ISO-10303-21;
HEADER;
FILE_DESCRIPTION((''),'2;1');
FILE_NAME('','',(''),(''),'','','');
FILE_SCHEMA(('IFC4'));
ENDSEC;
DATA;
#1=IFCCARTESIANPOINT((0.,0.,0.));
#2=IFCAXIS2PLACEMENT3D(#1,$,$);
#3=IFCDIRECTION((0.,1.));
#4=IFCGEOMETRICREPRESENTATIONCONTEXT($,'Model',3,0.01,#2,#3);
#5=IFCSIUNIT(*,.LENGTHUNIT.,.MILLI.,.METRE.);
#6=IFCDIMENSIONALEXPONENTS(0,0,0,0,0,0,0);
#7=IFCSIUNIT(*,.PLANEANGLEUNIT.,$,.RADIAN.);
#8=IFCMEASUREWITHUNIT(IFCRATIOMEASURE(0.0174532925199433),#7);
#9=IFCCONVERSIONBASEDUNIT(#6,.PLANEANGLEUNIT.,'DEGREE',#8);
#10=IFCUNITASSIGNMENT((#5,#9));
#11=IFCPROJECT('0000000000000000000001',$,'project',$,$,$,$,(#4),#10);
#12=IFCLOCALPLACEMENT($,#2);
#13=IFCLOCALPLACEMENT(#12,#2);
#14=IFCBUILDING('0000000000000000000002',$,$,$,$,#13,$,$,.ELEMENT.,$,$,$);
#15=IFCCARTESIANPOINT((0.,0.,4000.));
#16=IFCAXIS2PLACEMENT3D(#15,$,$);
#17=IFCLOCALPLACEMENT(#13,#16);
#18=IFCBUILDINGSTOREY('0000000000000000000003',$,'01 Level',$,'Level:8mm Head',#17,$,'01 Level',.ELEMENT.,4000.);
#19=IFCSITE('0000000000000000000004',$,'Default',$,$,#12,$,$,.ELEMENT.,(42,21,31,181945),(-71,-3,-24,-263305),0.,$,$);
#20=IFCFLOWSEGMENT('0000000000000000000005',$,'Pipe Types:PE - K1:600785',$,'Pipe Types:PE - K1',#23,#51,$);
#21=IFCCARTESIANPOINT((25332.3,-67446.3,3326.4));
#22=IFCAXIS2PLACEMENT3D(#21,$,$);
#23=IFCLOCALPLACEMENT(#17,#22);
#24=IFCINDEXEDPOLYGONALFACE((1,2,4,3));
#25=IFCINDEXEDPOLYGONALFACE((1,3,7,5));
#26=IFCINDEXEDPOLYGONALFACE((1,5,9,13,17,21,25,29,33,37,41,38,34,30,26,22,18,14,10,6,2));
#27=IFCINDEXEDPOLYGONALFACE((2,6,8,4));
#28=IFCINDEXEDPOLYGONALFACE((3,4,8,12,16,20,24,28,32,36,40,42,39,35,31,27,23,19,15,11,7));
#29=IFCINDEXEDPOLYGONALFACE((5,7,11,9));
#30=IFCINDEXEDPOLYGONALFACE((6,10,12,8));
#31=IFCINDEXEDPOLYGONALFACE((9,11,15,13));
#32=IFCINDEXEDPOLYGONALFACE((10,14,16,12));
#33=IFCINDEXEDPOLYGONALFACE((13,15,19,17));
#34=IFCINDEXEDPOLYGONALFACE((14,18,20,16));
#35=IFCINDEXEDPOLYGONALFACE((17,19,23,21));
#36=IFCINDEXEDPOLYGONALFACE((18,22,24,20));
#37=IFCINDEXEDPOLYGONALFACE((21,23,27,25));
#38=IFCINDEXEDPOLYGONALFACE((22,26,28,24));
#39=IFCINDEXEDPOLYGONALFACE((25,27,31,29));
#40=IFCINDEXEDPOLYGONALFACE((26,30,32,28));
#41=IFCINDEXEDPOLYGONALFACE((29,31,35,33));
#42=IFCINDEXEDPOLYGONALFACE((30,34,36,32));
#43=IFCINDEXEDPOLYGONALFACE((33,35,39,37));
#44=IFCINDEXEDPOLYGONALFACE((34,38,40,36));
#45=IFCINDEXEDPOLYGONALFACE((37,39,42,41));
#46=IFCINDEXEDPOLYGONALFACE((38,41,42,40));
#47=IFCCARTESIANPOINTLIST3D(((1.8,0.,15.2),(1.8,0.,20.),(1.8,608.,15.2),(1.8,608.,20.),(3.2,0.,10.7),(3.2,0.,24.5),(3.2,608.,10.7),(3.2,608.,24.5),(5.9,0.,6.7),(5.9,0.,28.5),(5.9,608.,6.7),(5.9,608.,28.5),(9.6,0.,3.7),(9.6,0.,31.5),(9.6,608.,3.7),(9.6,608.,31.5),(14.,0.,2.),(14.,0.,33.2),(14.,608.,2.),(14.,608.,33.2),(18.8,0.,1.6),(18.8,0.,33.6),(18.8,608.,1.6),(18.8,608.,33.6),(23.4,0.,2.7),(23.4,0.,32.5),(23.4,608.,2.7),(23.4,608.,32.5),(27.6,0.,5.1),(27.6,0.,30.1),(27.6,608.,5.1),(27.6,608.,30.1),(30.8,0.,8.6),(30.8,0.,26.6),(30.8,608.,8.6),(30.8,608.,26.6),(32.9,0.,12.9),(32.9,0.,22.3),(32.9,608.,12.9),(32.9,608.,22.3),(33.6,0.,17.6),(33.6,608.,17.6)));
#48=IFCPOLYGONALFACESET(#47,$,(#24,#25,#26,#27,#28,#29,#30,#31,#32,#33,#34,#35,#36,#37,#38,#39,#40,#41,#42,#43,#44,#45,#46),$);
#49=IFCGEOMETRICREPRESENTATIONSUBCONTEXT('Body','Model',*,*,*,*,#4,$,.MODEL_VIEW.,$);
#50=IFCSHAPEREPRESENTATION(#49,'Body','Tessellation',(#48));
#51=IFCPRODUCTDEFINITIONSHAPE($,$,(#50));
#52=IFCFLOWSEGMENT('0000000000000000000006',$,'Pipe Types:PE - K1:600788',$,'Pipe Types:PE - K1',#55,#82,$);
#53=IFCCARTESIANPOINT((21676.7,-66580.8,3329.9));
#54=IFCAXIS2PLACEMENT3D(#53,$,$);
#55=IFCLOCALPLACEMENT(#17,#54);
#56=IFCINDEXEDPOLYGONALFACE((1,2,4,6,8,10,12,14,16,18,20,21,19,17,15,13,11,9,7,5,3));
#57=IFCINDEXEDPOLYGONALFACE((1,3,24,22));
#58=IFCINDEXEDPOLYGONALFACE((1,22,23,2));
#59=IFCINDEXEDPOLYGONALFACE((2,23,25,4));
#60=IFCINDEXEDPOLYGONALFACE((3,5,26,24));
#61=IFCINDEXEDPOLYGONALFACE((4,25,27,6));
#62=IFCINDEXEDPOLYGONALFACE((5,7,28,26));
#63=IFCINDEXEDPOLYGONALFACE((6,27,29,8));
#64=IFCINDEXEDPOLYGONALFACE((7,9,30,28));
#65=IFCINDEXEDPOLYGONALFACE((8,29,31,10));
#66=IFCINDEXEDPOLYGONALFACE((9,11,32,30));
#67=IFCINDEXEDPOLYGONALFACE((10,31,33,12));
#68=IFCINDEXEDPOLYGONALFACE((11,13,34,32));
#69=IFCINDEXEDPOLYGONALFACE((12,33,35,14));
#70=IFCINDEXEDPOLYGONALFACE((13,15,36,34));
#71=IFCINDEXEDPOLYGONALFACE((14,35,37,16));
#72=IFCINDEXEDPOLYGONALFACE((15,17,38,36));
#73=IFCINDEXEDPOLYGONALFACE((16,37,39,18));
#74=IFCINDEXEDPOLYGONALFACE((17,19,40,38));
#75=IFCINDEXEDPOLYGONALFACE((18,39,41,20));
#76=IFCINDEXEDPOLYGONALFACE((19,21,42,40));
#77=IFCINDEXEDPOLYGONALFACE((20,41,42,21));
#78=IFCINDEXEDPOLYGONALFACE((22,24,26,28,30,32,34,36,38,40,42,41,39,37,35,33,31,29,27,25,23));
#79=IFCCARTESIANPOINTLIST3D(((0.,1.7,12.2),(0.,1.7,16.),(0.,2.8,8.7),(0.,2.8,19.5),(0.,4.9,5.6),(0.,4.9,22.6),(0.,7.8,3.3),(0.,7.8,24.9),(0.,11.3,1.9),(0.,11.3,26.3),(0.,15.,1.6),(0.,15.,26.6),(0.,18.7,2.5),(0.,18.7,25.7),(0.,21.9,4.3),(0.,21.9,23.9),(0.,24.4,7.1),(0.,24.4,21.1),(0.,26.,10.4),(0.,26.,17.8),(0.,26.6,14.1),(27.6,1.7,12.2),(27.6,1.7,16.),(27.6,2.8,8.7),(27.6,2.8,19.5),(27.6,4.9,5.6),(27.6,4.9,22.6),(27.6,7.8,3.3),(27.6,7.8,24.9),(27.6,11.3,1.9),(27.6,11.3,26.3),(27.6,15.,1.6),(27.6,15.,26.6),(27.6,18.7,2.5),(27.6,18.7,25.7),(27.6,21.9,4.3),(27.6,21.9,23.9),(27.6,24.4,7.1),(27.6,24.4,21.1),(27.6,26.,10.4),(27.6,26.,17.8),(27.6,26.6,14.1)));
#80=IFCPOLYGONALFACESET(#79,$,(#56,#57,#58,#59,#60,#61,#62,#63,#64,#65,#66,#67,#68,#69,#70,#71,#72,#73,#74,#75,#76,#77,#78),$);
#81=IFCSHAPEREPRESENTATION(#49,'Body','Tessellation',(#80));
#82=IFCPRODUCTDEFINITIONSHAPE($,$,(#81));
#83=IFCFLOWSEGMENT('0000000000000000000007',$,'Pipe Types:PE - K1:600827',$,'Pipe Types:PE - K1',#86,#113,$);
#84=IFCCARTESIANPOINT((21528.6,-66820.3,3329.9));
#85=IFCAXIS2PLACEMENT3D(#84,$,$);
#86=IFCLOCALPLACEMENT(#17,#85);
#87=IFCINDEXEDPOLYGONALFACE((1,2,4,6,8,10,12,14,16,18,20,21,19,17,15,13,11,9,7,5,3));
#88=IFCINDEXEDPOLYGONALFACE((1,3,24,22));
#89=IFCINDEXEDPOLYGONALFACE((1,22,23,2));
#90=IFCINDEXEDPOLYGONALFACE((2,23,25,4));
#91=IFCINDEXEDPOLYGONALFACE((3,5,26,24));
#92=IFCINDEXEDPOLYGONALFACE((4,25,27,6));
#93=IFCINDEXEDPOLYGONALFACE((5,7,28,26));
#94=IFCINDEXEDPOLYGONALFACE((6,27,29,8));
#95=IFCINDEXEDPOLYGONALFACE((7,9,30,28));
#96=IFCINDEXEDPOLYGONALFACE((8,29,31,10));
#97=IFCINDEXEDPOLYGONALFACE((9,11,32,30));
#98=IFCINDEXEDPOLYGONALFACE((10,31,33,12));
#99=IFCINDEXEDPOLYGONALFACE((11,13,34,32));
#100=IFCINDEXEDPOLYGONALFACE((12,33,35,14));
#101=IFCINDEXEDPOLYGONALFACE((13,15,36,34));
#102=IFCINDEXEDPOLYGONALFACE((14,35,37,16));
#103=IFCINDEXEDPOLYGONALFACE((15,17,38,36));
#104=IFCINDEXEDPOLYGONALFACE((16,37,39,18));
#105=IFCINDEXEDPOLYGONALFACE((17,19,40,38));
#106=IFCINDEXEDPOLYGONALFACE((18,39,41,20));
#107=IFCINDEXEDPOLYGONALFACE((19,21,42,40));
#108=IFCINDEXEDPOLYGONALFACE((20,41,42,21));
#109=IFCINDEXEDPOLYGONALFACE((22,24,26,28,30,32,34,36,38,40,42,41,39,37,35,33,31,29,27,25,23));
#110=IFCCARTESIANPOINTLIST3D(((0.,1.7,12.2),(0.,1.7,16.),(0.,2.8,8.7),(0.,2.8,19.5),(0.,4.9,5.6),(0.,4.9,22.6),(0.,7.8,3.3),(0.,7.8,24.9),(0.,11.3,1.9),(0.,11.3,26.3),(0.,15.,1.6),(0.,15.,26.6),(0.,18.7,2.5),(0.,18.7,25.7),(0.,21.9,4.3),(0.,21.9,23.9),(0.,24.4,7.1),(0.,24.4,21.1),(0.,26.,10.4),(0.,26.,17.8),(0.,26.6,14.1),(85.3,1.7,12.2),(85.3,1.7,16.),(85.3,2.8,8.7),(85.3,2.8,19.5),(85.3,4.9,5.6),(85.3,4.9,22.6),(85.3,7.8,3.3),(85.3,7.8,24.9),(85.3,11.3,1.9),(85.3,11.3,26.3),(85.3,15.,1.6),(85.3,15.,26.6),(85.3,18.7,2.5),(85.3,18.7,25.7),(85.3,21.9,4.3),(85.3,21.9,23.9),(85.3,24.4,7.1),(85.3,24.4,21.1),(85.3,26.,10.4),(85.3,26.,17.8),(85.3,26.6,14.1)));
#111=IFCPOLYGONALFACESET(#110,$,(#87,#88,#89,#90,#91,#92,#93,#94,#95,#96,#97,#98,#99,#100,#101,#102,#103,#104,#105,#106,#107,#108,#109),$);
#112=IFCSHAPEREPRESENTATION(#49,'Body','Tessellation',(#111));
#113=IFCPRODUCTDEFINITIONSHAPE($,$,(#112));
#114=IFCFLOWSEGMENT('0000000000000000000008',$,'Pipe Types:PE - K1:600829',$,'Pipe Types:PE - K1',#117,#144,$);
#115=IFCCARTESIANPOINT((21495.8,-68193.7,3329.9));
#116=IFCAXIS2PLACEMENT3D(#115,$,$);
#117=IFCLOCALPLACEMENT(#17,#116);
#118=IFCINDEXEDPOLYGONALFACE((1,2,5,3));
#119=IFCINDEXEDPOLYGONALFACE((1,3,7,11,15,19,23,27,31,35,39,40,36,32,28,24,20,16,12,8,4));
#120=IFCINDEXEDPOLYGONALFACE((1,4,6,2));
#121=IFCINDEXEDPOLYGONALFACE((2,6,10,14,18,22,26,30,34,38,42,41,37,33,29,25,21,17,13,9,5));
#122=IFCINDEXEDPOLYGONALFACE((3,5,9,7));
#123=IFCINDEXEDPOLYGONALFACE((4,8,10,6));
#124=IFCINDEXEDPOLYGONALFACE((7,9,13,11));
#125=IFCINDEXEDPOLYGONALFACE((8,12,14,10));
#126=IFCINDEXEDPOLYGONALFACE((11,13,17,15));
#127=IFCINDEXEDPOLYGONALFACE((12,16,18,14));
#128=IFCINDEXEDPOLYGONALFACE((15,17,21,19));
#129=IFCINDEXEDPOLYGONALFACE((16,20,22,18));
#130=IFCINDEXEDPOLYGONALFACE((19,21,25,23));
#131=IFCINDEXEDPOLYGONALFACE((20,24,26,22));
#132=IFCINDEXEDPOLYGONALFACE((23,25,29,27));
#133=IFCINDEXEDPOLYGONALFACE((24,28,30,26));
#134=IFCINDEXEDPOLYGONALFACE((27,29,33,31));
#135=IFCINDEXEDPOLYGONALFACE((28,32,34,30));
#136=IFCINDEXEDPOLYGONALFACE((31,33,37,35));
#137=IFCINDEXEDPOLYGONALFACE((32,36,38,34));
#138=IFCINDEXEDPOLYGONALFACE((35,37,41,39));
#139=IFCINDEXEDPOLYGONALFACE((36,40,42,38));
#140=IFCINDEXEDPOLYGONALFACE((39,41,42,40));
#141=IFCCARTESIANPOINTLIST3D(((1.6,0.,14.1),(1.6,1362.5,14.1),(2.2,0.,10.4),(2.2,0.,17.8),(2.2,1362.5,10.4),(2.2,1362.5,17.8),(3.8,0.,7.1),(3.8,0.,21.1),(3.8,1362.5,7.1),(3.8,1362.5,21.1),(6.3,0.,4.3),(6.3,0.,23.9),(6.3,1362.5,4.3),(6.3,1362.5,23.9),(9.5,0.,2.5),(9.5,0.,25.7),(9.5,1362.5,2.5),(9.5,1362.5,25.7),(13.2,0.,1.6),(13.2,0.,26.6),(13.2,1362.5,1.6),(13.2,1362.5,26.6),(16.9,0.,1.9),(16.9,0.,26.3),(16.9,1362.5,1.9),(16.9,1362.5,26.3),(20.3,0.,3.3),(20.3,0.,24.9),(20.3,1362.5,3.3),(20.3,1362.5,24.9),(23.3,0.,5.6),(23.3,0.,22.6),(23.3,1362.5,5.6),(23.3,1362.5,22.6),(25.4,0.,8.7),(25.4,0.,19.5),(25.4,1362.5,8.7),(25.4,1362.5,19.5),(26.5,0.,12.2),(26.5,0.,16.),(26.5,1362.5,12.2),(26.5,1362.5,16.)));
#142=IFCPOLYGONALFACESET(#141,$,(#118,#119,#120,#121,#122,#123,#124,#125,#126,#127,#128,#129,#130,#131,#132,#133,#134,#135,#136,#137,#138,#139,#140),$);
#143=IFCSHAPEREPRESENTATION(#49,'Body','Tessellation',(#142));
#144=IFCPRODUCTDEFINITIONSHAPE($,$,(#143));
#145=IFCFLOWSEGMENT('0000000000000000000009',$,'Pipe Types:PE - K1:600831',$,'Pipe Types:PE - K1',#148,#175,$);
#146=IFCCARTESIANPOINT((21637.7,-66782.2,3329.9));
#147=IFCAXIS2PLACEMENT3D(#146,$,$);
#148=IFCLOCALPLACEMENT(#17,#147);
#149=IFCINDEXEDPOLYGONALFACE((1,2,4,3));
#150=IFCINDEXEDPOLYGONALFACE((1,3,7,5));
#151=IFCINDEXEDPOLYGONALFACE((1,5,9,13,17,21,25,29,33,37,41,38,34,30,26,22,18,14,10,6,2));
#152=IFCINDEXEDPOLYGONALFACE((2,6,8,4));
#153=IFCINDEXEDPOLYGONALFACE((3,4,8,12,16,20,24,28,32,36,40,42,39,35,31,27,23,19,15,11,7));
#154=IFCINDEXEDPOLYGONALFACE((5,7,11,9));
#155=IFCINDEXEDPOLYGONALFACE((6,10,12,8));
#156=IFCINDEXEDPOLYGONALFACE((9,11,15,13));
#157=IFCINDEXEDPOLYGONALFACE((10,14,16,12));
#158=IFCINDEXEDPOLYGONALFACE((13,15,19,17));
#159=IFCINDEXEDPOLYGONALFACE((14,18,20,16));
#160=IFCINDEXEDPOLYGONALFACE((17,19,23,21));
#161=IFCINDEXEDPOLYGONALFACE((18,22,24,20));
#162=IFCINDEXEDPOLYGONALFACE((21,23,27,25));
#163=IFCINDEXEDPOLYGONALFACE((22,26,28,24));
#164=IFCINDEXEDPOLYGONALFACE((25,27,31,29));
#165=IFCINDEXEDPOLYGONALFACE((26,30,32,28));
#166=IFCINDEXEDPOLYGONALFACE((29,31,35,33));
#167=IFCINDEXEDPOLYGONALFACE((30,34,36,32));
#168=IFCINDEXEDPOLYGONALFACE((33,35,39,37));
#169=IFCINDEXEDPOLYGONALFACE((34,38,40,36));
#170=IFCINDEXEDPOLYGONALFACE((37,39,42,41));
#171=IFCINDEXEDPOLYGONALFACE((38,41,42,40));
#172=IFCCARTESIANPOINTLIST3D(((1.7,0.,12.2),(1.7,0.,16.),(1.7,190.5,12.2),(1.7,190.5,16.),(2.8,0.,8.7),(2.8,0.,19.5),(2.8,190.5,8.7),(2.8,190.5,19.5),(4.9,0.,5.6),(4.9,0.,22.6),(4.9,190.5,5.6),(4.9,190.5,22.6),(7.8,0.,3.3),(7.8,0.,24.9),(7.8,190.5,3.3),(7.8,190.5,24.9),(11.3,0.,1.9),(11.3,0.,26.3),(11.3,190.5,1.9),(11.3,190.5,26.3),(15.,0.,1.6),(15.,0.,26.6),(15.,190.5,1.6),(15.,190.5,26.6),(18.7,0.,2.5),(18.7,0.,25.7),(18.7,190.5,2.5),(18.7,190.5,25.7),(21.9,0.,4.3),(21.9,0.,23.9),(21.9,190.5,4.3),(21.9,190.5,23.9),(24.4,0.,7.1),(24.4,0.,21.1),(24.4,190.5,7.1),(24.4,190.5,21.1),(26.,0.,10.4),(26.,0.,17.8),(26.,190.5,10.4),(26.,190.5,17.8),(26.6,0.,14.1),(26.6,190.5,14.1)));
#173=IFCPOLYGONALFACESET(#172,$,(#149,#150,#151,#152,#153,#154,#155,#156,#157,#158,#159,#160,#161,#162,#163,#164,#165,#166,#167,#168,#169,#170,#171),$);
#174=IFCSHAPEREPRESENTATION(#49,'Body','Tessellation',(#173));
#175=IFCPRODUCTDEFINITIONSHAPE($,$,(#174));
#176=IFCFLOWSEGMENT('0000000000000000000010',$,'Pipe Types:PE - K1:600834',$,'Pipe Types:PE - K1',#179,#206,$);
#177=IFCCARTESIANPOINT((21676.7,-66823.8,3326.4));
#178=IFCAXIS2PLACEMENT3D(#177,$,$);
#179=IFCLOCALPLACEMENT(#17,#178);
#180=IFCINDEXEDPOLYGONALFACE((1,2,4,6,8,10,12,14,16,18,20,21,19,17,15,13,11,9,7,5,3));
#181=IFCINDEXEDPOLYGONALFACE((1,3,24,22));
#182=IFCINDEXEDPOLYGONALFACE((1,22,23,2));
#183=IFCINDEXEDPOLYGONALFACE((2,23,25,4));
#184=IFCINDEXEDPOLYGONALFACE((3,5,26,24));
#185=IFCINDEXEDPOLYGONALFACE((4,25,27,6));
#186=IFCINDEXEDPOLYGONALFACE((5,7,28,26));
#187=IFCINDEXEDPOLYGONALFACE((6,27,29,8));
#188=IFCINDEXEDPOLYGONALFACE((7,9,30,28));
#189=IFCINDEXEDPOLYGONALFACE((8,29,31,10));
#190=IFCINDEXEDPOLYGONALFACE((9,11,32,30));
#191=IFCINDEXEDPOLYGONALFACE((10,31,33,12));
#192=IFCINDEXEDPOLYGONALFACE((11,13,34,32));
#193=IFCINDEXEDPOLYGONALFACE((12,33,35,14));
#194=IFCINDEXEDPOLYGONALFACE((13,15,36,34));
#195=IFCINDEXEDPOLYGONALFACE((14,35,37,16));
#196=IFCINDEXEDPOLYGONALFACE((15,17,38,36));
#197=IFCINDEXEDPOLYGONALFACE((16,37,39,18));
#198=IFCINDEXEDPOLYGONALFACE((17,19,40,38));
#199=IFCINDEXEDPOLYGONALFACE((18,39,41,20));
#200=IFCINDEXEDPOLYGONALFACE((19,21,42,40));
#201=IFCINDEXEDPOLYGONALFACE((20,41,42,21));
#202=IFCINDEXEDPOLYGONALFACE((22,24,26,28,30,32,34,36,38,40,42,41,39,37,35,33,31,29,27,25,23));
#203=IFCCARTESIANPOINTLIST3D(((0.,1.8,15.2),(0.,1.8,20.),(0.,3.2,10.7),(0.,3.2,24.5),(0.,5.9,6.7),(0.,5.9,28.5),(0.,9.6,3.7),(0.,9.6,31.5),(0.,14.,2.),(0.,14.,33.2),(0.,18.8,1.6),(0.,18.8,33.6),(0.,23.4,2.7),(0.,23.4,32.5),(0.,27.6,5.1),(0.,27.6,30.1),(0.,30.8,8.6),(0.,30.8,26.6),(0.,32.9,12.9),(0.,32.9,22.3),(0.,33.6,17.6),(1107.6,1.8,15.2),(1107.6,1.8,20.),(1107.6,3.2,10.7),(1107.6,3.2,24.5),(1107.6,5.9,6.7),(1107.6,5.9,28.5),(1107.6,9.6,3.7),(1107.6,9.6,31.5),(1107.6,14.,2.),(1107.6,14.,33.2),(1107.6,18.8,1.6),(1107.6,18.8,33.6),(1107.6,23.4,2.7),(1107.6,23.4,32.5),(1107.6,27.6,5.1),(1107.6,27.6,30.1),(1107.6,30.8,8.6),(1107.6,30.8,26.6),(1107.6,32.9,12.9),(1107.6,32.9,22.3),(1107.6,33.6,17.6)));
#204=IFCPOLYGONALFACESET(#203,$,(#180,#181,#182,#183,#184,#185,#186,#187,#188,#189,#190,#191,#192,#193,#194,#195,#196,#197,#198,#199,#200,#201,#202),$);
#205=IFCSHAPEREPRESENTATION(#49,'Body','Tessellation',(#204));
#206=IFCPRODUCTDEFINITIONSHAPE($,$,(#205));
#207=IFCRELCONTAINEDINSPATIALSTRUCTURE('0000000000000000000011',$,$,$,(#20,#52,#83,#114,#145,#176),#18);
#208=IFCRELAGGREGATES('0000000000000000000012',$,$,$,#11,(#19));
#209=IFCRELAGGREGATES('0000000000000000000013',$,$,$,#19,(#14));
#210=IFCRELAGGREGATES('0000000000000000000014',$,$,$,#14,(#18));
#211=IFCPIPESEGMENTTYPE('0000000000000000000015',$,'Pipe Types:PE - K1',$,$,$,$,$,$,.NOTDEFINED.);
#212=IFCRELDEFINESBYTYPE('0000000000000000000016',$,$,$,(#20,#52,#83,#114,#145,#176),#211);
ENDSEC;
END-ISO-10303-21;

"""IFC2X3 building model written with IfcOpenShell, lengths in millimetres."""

from ifc_helpers import new_model, entity, si_unit, converted_unit, direction, frame, frame_2d, origin, origin_2d_with_axis, place, context, subcontext, project, spatial, circle, extrude, type_object, element, save


model = new_model("IFC2X3")

# Units and contexts
model_context = context("Model", 3, precision=0.01, world=origin(), true_north=direction((0.0, 1.0)))
body_context = subcontext(model_context, "Body", "Model", "MODEL_VIEW")
ifc_project = project(units=[si_unit("LENGTHUNIT", "METRE", prefix="MILLI"), converted_unit("PLANEANGLEUNIT", "DEGREE", entity("IfcRatioMeasure", 0.0174532925199433), si_unit("PLANEANGLEUNIT", "RADIAN"), dimensions=[0, 0, 0, 0, 0, 0, 0])], contexts=[model_context])

# Site, building, storey
site_placement = place(None, origin())
site = spatial("IfcSite", under=ifc_project, at=site_placement, Name="Default", CompositionType="ELEMENT", RefLatitude=(42, 21, 31, 181945), RefLongitude=(-71, -3, -24, -263305), RefElevation=0.0)
building_placement = place(site_placement, origin())
building = spatial("IfcBuilding", under=site, at=building_placement, CompositionType="ELEMENT")
storey_placement = place(building_placement, frame((0.0, 0.0, 4000.0)))
storey = spatial("IfcBuildingStorey", under=building, at=storey_placement, Name="01 Level", ObjectType="Level:8mm Head", LongName="01 Level", CompositionType="ELEMENT", Elevation=4000.0)

# Flow segments
pipe_segment_type = type_object("IfcPipeSegmentType", Name="Pipe Types:PE - K1", PredefinedType="NOTDEFINED")
flow_segment_1_placement = place(storey_placement, frame((25332.3, -67446.3, 3326.4)))
element("IfcFlowSegment", 1, at=flow_segment_1_placement, inside=storey, type_object=pipe_segment_type, Name="Pipe Types:PE - K1:600785", ObjectType="Pipe Types:PE - K1", context=body_context, shape_type="SweptSolid", body=[
    extrude(circle(Radius=16.0, at=origin_2d_with_axis()), frame((17.6, 0.0, 17.6), z_axis=(0.0, 1.0, 0.0), x_axis=(1.0, 0.0, 0.0)), (0.0, 0.0, 1.0), 608.0),
])
flow_segment_2_placement = place(storey_placement, frame((21676.7, -66580.8, 3329.9)))
element("IfcFlowSegment", 2, at=flow_segment_2_placement, inside=storey, type_object=pipe_segment_type, Name="Pipe Types:PE - K1:600788", ObjectType="Pipe Types:PE - K1", context=body_context, shape_type="SweptSolid", body=[
    extrude(circle(Radius=12.5, at=frame_2d((0.0, 0.0), x_axis=(1.0, 0.0))), frame((0.0, 14.1, 14.1), z_axis=(1.0, 0.0, 0.0), x_axis=(0.0, 1.0, 0.0)), (0.0, 0.0, 1.0), 27.6),
])
flow_segment_3_placement = place(storey_placement, frame((21528.6, -66820.3, 3329.9)))
element("IfcFlowSegment", 3, at=flow_segment_3_placement, inside=storey, type_object=pipe_segment_type, Name="Pipe Types:PE - K1:600827", ObjectType="Pipe Types:PE - K1", context=body_context, shape_type="SweptSolid", body=[
    extrude(circle(Radius=12.5, at=frame_2d((0.0, 0.0), x_axis=(1.0, 0.0))), frame((0.0, 14.1, 14.1), z_axis=(1.0, 0.0, 0.0), x_axis=(0.0, 1.0, 0.0)), (0.0, 0.0, 1.0), 85.3),
])
flow_segment_4_placement = place(storey_placement, frame((21495.8, -68193.7, 3329.9)))
element("IfcFlowSegment", 4, at=flow_segment_4_placement, inside=storey, type_object=pipe_segment_type, Name="Pipe Types:PE - K1:600829", ObjectType="Pipe Types:PE - K1", context=body_context, shape_type="SweptSolid", body=[
    extrude(circle(Radius=12.5, at=frame_2d((0.0, 0.0), x_axis=(1.0, 0.0))), frame((14.1, 0.0, 14.1), z_axis=(0.0, 1.0, 0.0), x_axis=(-1.0, 0.0, 0.0)), (0.0, 0.0, 1.0), 1362.5),
])
flow_segment_5_placement = place(storey_placement, frame((21637.7, -66782.2, 3329.9)))
element("IfcFlowSegment", 5, at=flow_segment_5_placement, inside=storey, type_object=pipe_segment_type, Name="Pipe Types:PE - K1:600831", ObjectType="Pipe Types:PE - K1", context=body_context, shape_type="SweptSolid", body=[
    extrude(circle(Radius=12.5, at=origin_2d_with_axis()), frame((14.1, 0.0, 14.1), z_axis=(0.0, 1.0, 0.0), x_axis=(1.0, 0.0, 0.0)), (0.0, 0.0, 1.0), 190.5),
])
flow_segment_6_placement = place(storey_placement, frame((21676.7, -66823.8, 3326.4)))
element("IfcFlowSegment", 6, at=flow_segment_6_placement, inside=storey, type_object=pipe_segment_type, Name="Pipe Types:PE - K1:600834", ObjectType="Pipe Types:PE - K1", context=body_context, shape_type="SweptSolid", body=[
    extrude(circle(Radius=16.0, at=frame_2d((0.0, 0.0), x_axis=(1.0, 0.0))), frame((0.0, 17.6, 17.6), z_axis=(1.0, 0.0, 0.0), x_axis=(0.0, 1.0, 0.0)), (0.0, 0.0, 1.0), 1107.6),
])

save(model, "model.ifc")
